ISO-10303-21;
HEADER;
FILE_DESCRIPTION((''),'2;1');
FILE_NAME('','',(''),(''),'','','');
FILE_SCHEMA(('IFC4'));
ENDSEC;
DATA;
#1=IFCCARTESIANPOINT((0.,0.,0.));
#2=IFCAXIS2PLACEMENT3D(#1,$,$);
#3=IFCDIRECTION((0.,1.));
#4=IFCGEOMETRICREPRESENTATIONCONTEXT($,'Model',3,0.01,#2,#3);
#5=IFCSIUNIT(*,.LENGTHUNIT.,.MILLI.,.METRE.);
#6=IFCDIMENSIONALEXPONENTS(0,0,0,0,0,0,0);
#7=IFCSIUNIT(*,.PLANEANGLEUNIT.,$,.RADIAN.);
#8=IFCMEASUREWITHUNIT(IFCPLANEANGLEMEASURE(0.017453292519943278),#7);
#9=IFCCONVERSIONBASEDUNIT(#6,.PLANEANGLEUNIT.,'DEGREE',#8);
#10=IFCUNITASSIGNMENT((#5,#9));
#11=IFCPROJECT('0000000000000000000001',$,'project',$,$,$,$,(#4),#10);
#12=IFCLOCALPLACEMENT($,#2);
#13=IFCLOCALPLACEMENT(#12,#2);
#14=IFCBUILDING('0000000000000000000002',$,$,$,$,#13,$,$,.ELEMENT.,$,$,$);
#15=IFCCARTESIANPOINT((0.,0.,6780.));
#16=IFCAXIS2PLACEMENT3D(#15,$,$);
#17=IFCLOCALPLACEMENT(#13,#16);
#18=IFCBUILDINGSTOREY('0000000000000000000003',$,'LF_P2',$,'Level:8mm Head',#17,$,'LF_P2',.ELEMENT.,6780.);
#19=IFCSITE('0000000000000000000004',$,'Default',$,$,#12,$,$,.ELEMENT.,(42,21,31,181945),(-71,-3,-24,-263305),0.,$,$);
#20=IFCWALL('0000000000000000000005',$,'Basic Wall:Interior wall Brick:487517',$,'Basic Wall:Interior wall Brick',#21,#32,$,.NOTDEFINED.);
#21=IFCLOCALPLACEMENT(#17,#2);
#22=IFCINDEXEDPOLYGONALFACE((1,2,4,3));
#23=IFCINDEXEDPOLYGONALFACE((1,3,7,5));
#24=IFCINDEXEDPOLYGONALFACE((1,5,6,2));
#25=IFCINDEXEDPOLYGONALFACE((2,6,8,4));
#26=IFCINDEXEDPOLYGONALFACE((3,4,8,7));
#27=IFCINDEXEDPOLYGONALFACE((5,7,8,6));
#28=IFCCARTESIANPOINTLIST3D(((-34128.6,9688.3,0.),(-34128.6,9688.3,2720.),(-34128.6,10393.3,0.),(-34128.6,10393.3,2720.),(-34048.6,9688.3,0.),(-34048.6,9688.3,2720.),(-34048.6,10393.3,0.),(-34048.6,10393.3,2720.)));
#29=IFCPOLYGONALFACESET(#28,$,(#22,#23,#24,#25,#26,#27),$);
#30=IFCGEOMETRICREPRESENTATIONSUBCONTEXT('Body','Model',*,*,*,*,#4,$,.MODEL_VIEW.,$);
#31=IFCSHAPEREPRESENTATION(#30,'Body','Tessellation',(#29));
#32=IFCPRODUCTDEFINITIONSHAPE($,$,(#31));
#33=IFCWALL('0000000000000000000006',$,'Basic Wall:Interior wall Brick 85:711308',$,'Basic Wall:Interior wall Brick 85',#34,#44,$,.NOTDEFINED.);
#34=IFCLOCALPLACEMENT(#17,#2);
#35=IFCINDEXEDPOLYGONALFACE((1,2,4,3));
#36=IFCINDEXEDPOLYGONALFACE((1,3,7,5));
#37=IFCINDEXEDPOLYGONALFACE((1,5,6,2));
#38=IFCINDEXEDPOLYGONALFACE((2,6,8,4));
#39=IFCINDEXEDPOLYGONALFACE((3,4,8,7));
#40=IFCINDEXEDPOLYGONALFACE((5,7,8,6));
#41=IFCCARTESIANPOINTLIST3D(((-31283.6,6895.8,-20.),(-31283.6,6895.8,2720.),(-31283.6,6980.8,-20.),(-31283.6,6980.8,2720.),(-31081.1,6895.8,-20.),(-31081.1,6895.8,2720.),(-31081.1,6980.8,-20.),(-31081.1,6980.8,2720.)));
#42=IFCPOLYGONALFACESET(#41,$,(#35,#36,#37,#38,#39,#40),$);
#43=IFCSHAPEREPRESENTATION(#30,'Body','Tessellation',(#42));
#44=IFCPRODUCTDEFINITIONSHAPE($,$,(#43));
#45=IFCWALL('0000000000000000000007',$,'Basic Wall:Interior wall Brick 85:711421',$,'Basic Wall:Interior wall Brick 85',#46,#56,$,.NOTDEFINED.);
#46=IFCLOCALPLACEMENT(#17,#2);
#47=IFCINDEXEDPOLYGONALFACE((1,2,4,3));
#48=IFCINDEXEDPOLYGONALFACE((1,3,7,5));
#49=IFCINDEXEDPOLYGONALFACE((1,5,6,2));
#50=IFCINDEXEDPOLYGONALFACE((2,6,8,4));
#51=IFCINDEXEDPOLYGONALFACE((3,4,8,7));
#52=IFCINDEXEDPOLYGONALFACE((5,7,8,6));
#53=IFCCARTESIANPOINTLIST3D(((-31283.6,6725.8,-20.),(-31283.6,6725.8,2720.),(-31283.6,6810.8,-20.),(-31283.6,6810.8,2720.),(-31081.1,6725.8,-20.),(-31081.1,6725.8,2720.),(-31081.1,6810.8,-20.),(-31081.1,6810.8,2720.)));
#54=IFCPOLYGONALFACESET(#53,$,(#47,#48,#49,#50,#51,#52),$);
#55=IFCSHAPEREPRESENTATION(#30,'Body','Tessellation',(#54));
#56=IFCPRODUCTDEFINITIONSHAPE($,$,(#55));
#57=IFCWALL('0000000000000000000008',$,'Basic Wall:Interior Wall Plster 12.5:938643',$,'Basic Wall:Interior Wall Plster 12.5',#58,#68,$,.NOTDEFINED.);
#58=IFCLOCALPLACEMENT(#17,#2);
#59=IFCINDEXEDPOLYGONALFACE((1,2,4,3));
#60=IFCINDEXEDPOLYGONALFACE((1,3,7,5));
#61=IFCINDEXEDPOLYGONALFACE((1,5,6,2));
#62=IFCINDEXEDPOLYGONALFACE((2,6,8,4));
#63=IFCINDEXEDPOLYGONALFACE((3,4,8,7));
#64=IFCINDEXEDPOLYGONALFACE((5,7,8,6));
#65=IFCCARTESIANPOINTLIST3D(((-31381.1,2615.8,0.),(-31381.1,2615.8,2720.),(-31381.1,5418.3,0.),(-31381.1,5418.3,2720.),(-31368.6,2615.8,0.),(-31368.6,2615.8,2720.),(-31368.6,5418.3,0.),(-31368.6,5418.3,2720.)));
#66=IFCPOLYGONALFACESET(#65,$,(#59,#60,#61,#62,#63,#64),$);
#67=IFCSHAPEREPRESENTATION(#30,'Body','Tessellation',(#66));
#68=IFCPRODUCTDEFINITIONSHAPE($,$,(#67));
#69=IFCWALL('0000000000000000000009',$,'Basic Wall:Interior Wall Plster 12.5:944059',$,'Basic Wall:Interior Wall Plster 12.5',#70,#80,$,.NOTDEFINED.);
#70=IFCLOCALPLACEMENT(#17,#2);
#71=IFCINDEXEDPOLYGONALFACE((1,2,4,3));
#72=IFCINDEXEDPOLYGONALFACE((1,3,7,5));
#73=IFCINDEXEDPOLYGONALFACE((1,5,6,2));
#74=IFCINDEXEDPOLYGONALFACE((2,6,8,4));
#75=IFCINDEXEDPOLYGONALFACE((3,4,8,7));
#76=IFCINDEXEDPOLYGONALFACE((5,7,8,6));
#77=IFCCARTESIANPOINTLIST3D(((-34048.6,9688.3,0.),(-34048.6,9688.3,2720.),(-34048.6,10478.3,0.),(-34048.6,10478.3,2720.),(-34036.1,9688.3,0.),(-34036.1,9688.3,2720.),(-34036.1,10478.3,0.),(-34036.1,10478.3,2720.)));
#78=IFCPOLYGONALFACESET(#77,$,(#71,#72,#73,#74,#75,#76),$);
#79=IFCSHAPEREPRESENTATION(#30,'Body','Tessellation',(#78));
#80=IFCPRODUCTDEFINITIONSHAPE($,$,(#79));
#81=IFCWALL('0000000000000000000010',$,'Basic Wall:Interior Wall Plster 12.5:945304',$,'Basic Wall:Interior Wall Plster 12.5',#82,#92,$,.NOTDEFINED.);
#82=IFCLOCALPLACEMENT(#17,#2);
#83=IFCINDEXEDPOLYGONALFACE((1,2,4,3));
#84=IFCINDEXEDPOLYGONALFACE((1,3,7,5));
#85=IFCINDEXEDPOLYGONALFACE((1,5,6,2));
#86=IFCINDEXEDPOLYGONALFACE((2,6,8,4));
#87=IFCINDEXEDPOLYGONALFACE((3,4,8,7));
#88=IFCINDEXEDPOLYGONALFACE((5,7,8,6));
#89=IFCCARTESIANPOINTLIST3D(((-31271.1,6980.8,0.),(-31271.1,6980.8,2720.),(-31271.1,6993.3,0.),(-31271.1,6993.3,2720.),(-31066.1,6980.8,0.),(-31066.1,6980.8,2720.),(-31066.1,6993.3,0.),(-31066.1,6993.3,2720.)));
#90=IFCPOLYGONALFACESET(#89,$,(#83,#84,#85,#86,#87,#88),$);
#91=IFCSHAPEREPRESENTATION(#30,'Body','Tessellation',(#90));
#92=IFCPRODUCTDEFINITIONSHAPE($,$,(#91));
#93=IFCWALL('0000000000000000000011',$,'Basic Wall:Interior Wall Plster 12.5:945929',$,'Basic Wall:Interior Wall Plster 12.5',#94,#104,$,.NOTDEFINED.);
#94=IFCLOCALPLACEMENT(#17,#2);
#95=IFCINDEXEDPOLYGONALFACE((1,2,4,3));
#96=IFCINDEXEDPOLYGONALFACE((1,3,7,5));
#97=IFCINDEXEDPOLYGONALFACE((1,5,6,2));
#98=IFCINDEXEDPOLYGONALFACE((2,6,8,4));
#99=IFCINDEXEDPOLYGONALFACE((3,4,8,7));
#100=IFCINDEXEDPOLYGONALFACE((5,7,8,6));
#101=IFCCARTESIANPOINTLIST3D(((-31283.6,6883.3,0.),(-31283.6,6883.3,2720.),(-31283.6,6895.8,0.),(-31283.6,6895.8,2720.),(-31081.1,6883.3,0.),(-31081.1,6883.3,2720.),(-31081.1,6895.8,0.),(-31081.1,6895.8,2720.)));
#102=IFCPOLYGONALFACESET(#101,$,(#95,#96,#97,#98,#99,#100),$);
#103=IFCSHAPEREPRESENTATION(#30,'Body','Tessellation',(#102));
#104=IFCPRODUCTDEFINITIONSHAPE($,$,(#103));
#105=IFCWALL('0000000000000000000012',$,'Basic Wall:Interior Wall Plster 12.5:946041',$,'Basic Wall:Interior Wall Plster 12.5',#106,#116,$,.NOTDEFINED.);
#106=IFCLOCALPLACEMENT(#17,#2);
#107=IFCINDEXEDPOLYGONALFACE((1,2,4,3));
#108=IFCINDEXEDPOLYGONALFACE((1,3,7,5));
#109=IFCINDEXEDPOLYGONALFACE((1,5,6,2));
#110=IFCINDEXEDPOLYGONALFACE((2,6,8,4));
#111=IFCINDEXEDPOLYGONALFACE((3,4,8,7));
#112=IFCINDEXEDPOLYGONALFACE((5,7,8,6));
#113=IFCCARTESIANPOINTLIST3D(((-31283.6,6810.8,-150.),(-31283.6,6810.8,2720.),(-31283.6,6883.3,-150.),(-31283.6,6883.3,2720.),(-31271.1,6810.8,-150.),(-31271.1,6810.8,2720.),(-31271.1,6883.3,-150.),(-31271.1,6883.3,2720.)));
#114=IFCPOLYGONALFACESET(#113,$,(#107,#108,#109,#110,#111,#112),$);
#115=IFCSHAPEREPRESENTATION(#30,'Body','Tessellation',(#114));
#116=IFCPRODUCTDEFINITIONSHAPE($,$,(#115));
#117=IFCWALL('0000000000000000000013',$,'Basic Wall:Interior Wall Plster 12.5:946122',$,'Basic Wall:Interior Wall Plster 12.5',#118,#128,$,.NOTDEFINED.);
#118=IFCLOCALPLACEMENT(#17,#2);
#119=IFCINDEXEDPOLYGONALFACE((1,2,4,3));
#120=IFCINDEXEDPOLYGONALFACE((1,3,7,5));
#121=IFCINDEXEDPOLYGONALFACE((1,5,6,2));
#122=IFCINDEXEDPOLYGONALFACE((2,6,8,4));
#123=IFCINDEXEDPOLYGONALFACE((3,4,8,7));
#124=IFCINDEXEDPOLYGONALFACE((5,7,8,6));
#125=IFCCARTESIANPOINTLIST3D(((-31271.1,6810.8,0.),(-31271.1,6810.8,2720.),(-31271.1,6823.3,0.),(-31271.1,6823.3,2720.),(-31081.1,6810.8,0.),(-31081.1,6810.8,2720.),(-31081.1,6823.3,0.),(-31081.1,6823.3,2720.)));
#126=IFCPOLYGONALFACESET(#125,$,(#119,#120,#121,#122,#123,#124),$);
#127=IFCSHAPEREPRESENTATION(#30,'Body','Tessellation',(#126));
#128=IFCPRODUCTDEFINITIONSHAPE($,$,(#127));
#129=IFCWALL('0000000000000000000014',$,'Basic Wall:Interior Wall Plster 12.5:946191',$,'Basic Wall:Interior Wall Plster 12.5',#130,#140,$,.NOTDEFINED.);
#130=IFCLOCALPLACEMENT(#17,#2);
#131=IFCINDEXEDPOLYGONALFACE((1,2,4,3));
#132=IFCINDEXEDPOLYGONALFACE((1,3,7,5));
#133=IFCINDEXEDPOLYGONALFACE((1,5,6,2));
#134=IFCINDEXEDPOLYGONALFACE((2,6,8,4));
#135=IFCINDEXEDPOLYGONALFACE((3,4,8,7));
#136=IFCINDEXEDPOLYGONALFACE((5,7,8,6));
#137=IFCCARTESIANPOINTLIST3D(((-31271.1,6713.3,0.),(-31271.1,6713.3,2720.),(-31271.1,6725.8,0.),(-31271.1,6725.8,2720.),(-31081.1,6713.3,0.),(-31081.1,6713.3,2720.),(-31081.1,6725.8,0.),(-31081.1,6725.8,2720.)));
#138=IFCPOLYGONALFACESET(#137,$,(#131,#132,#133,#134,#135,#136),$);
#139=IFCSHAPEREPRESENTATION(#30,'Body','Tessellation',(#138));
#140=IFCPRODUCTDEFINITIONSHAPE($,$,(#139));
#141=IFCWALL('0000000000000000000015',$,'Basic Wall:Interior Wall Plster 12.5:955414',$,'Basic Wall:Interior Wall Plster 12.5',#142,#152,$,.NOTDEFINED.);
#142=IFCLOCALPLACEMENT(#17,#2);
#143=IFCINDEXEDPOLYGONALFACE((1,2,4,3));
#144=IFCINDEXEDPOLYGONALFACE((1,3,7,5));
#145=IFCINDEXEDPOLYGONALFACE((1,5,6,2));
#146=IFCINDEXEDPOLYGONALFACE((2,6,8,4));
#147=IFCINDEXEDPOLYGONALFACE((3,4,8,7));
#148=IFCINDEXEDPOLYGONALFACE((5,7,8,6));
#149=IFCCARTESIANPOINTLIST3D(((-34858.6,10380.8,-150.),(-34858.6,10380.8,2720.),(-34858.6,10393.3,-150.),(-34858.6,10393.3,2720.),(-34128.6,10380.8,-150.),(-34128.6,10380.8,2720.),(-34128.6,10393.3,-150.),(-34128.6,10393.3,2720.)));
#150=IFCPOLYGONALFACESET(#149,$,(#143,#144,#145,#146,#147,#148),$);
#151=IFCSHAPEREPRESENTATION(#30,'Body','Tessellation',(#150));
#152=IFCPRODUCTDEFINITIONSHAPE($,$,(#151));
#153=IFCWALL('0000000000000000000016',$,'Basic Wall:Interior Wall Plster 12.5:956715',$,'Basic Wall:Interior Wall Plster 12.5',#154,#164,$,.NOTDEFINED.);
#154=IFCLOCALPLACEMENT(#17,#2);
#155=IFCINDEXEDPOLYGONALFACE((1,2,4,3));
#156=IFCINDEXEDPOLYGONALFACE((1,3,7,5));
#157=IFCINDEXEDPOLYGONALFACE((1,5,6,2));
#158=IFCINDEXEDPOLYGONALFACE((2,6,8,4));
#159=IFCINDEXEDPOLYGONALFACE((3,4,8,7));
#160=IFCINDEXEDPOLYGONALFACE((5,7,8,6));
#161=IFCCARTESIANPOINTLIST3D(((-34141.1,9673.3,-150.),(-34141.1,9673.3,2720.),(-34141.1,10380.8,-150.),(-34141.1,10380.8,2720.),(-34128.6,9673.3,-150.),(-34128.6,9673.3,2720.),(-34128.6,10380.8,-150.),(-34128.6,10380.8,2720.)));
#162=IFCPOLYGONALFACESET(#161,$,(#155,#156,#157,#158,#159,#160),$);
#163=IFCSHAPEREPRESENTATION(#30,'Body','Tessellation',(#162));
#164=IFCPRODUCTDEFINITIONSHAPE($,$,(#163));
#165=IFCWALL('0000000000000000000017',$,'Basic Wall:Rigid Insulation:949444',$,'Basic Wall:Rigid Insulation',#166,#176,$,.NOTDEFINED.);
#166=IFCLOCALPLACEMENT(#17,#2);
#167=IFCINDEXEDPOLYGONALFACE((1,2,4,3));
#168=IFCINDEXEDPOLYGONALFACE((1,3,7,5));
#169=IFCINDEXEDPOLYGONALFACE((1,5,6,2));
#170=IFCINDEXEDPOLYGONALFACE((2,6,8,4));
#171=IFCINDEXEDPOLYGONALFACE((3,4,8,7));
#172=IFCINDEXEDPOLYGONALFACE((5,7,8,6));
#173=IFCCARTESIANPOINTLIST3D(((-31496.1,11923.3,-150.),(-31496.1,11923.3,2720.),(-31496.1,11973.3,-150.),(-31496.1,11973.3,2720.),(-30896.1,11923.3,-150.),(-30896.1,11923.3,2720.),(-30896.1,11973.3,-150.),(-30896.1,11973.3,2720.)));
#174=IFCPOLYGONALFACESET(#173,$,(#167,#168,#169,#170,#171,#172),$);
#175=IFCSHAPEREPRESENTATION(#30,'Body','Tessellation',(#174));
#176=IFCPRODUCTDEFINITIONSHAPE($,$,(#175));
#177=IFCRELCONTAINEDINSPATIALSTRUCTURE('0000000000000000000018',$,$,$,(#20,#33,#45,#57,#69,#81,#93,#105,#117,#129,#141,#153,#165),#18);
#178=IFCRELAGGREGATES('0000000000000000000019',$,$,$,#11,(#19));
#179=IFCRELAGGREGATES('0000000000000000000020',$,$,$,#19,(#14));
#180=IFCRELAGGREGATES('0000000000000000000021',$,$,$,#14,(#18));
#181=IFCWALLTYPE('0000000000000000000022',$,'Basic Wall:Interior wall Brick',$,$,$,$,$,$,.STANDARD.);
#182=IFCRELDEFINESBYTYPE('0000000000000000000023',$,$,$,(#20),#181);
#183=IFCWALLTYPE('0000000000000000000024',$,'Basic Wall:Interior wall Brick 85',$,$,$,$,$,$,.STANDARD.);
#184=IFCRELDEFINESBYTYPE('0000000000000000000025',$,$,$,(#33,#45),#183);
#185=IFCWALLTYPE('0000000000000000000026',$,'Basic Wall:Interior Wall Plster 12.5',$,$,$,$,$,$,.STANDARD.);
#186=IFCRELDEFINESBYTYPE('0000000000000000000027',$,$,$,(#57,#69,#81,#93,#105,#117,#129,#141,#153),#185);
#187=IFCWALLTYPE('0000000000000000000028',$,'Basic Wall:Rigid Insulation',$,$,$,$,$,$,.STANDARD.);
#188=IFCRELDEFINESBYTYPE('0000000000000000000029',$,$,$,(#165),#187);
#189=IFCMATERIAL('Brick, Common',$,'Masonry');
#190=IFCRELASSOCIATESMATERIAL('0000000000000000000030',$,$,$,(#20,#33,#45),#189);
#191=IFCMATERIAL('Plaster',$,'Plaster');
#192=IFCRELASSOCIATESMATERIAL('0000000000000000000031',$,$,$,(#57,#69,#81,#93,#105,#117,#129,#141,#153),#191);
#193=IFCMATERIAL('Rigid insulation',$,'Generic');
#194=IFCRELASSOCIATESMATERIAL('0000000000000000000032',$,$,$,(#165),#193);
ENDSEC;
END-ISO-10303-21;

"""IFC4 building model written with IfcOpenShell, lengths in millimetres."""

from ifc_helpers import new_model, entity, si_unit, converted_unit, direction, frame, origin, place, context, subcontext, project, spatial, indexed_curve, outline, extrude, material, type_object, element, save


model = new_model("IFC4")

# Units and contexts
model_context = context("Model", 3, precision=0.01, world=origin(), true_north=direction((0.0, 1.0)))
body_context = subcontext(model_context, "Body", "Model", "MODEL_VIEW")
ifc_project = project(units=[si_unit("LENGTHUNIT", "METRE", prefix="MILLI"), converted_unit("PLANEANGLEUNIT", "DEGREE", entity("IfcPlaneAngleMeasure", 0.017453292519943278), si_unit("PLANEANGLEUNIT", "RADIAN"), dimensions=[0, 0, 0, 0, 0, 0, 0])], contexts=[model_context])

# Site, building, storey
site_placement = place(None, origin())
site = spatial("IfcSite", under=ifc_project, at=site_placement, Name="Default", CompositionType="ELEMENT", RefLatitude=(42, 21, 31, 181945), RefLongitude=(-71, -3, -24, -263305), RefElevation=0.0)
building_placement = place(site_placement, origin())
building = spatial("IfcBuilding", under=site, at=building_placement, CompositionType="ELEMENT")
storey_placement = place(building_placement, frame((0.0, 0.0, 6780.0)))
storey = spatial("IfcBuildingStorey", under=building, at=storey_placement, Name="LF_P2", ObjectType="Level:8mm Head", LongName="LF_P2", CompositionType="ELEMENT", Elevation=6780.0)

# Walls
ifc_material_1 = material(Name="Brick, Common", Category="Masonry")
wall_type_1 = type_object("IfcWallType", Name="Basic Wall:Interior wall Brick", PredefinedType="STANDARD")
wall_1_placement = place(storey_placement, frame((-34088.6, 9688.3, 0.0), z_axis=(0.0, 0.0, 1.0), x_axis=(0.0, 1.0, 0.0)))
element("IfcWall", 1, at=wall_1_placement, inside=storey, type_object=wall_type_1, material=ifc_material_1, Name="Basic Wall:Interior wall Brick:487517", ObjectType="Basic Wall:Interior wall Brick", PredefinedType="NOTDEFINED", context=body_context, shape_type="SweptSolid", body=[
    extrude(outline(indexed_curve([(705.0, 40.0), (0.0, 40.0), (0.0, -40.0), (705.0, -40.0), (705.0, 40.0)], self_intersect=False)), origin(), (0.0, 0.0, 1.0), 2720.0),
])
wall_type_2 = type_object("IfcWallType", Name="Basic Wall:Interior wall Brick 85", PredefinedType="STANDARD")
for number, where, name in (
    (2, (-31283.6, 6938.3, -20.0), "Basic Wall:Interior wall Brick 85:711308"),
    (3, (-31283.6, 6768.3, -20.0), "Basic Wall:Interior wall Brick 85:711421"),
):
    element("IfcWall", number, at=place(storey_placement, frame(where)), inside=storey, type_object=wall_type_2, material=ifc_material_1, Name=name, ObjectType="Basic Wall:Interior wall Brick 85", PredefinedType="NOTDEFINED", context=body_context, shape_type="SweptSolid", body=[
        extrude(outline(indexed_curve([(202.5, 42.5), (0.0, 42.5), (0.0, -42.5), (202.5, -42.5), (202.5, 42.5)], self_intersect=False)), origin(), (0.0, 0.0, 1.0), 2740.0),
    ])
ifc_material_2 = material(Name="Plaster", Category="Plaster")
wall_type_3 = type_object("IfcWallType", Name="Basic Wall:Interior Wall Plster 12.5", PredefinedType="STANDARD")
wall_2_placement = place(storey_placement, frame((-31374.9, 5418.3, 0.0), z_axis=(0.0, 0.0, 1.0), x_axis=(0.0, -1.0, 0.0)))
element("IfcWall", 4, at=wall_2_placement, inside=storey, type_object=wall_type_3, material=ifc_material_2, Name="Basic Wall:Interior Wall Plster 12.5:938643", ObjectType="Basic Wall:Interior Wall Plster 12.5", PredefinedType="NOTDEFINED", context=body_context, shape_type="SweptSolid", body=[
    extrude(outline(indexed_curve([(2802.5, 6.2), (0.0, 6.2), (0.0, -6.2), (2802.5, -6.2), (2802.5, 6.2)], self_intersect=False)), origin(), (0.0, 0.0, 1.0), 2720.0),
])
wall_3_placement = place(storey_placement, frame((-34042.4, 10478.3, 0.0), z_axis=(0.0, 0.0, 1.0), x_axis=(0.0, -1.0, 0.0)))
element("IfcWall", 5, at=wall_3_placement, inside=storey, type_object=wall_type_3, material=ifc_material_2, Name="Basic Wall:Interior Wall Plster 12.5:944059", ObjectType="Basic Wall:Interior Wall Plster 12.5", PredefinedType="NOTDEFINED", context=body_context, shape_type="SweptSolid", body=[
    extrude(outline(indexed_curve([(790.0, 6.2), (0.0, 6.2), (0.0, -6.2), (790.0, -6.2), (790.0, 6.2)], self_intersect=False)), origin(), (0.0, 0.0, 1.0), 2720.0),
])
wall_4_placement = place(storey_placement, frame((-31271.1, 6987.1, 0.0)))
element("IfcWall", 6, at=wall_4_placement, inside=storey, type_object=wall_type_3, material=ifc_material_2, Name="Basic Wall:Interior Wall Plster 12.5:945304", ObjectType="Basic Wall:Interior Wall Plster 12.5", PredefinedType="NOTDEFINED", context=body_context, shape_type="SweptSolid", body=[
    extrude(outline(indexed_curve([(205.0, 6.2), (0.0, 6.2), (0.0, -6.2), (205.0, -6.2), (205.0, 6.2)], self_intersect=False)), origin(), (0.0, 0.0, 1.0), 2720.0),
])
wall_5_placement = place(storey_placement, frame((-31283.6, 6889.6, 0.0)))
element("IfcWall", 7, at=wall_5_placement, inside=storey, type_object=wall_type_3, material=ifc_material_2, Name="Basic Wall:Interior Wall Plster 12.5:945929", ObjectType="Basic Wall:Interior Wall Plster 12.5", PredefinedType="NOTDEFINED", context=body_context, shape_type="SweptSolid", body=[
    extrude(outline(indexed_curve([(202.5, 6.2), (0.0, 6.2), (0.0, -6.2), (202.5, -6.2), (202.5, 6.2)], self_intersect=False)), origin(), (0.0, 0.0, 1.0), 2720.0),
])
wall_6_placement = place(storey_placement, frame((-31277.4, 6883.3, -150.0), z_axis=(0.0, 0.0, 1.0), x_axis=(0.0, -1.0, 0.0)))
element("IfcWall", 8, at=wall_6_placement, inside=storey, type_object=wall_type_3, material=ifc_material_2, Name="Basic Wall:Interior Wall Plster 12.5:946041", ObjectType="Basic Wall:Interior Wall Plster 12.5", PredefinedType="NOTDEFINED", context=body_context, shape_type="SweptSolid", body=[
    extrude(outline(indexed_curve([(72.5, 6.2), (0.0, 6.2), (0.0, -6.2), (72.5, -6.2), (72.5, 6.2)], self_intersect=False)), origin(), (0.0, 0.0, 1.0), 2870.0),
])
wall_7_placement = place(storey_placement, frame((-31271.1, 6817.1, 0.0)))
element("IfcWall", 9, at=wall_7_placement, inside=storey, type_object=wall_type_3, material=ifc_material_2, Name="Basic Wall:Interior Wall Plster 12.5:946122", ObjectType="Basic Wall:Interior Wall Plster 12.5", PredefinedType="NOTDEFINED", context=body_context, shape_type="SweptSolid", body=[
    extrude(outline(indexed_curve([(190.0, 6.2), (0.0, 6.2), (0.0, -6.2), (190.0, -6.2), (190.0, 6.2)], self_intersect=False)), origin(), (0.0, 0.0, 1.0), 2720.0),
])
wall_8_placement = place(storey_placement, frame((-31271.1, 6719.6, 0.0)))
element("IfcWall", 10, at=wall_8_placement, inside=storey, type_object=wall_type_3, material=ifc_material_2, Name="Basic Wall:Interior Wall Plster 12.5:946191", ObjectType="Basic Wall:Interior Wall Plster 12.5", PredefinedType="NOTDEFINED", context=body_context, shape_type="SweptSolid", body=[
    extrude(outline(indexed_curve([(190.0, 6.2), (0.0, 6.2), (0.0, -6.2), (190.0, -6.2), (190.0, 6.2)], self_intersect=False)), origin(), (0.0, 0.0, 1.0), 2720.0),
])
wall_9_placement = place(storey_placement, frame((-34128.6, 10387.1, -150.0), z_axis=(0.0, 0.0, 1.0), x_axis=(-1.0, 0.0, 0.0)))
element("IfcWall", 11, at=wall_9_placement, inside=storey, type_object=wall_type_3, material=ifc_material_2, Name="Basic Wall:Interior Wall Plster 12.5:955414", ObjectType="Basic Wall:Interior Wall Plster 12.5", PredefinedType="NOTDEFINED", context=body_context, shape_type="SweptSolid", body=[
    extrude(outline(indexed_curve([(730.0, 6.3), (0.0, 6.3), (0.0, -6.3), (730.0, -6.3), (730.0, 6.3)], self_intersect=False)), origin(), (0.0, 0.0, 1.0), 2870.0),
])
wall_10_placement = place(storey_placement, frame((-34134.9, 10380.8, -150.0), z_axis=(0.0, 0.0, 1.0), x_axis=(0.0, -1.0, 0.0)))
element("IfcWall", 12, at=wall_10_placement, inside=storey, type_object=wall_type_3, material=ifc_material_2, Name="Basic Wall:Interior Wall Plster 12.5:956715", ObjectType="Basic Wall:Interior Wall Plster 12.5", PredefinedType="NOTDEFINED", context=body_context, shape_type="SweptSolid", body=[
    extrude(outline(indexed_curve([(707.5, 6.2), (0.0, 6.2), (0.0, -6.2), (707.5, -6.2), (707.5, 6.2)], self_intersect=False)), origin(), (0.0, 0.0, 1.0), 2870.0),
])
ifc_material_3 = material(Name="Rigid insulation", Category="Generic")
wall_type_4 = type_object("IfcWallType", Name="Basic Wall:Rigid Insulation", PredefinedType="STANDARD")
wall_11_placement = place(storey_placement, frame((-31496.1, 11948.3, -150.0)))
element("IfcWall", 13, at=wall_11_placement, inside=storey, type_object=wall_type_4, material=ifc_material_3, Name="Basic Wall:Rigid Insulation:949444", ObjectType="Basic Wall:Rigid Insulation", PredefinedType="NOTDEFINED", context=body_context, shape_type="SweptSolid", body=[
    extrude(outline(indexed_curve([(600.0, 25.0), (0.0, 25.0), (0.0, -25.0), (600.0, -25.0), (600.0, 25.0)], self_intersect=False)), origin(), (0.0, 0.0, 1.0), 2870.0),
])

save(model, "model.ifc")
